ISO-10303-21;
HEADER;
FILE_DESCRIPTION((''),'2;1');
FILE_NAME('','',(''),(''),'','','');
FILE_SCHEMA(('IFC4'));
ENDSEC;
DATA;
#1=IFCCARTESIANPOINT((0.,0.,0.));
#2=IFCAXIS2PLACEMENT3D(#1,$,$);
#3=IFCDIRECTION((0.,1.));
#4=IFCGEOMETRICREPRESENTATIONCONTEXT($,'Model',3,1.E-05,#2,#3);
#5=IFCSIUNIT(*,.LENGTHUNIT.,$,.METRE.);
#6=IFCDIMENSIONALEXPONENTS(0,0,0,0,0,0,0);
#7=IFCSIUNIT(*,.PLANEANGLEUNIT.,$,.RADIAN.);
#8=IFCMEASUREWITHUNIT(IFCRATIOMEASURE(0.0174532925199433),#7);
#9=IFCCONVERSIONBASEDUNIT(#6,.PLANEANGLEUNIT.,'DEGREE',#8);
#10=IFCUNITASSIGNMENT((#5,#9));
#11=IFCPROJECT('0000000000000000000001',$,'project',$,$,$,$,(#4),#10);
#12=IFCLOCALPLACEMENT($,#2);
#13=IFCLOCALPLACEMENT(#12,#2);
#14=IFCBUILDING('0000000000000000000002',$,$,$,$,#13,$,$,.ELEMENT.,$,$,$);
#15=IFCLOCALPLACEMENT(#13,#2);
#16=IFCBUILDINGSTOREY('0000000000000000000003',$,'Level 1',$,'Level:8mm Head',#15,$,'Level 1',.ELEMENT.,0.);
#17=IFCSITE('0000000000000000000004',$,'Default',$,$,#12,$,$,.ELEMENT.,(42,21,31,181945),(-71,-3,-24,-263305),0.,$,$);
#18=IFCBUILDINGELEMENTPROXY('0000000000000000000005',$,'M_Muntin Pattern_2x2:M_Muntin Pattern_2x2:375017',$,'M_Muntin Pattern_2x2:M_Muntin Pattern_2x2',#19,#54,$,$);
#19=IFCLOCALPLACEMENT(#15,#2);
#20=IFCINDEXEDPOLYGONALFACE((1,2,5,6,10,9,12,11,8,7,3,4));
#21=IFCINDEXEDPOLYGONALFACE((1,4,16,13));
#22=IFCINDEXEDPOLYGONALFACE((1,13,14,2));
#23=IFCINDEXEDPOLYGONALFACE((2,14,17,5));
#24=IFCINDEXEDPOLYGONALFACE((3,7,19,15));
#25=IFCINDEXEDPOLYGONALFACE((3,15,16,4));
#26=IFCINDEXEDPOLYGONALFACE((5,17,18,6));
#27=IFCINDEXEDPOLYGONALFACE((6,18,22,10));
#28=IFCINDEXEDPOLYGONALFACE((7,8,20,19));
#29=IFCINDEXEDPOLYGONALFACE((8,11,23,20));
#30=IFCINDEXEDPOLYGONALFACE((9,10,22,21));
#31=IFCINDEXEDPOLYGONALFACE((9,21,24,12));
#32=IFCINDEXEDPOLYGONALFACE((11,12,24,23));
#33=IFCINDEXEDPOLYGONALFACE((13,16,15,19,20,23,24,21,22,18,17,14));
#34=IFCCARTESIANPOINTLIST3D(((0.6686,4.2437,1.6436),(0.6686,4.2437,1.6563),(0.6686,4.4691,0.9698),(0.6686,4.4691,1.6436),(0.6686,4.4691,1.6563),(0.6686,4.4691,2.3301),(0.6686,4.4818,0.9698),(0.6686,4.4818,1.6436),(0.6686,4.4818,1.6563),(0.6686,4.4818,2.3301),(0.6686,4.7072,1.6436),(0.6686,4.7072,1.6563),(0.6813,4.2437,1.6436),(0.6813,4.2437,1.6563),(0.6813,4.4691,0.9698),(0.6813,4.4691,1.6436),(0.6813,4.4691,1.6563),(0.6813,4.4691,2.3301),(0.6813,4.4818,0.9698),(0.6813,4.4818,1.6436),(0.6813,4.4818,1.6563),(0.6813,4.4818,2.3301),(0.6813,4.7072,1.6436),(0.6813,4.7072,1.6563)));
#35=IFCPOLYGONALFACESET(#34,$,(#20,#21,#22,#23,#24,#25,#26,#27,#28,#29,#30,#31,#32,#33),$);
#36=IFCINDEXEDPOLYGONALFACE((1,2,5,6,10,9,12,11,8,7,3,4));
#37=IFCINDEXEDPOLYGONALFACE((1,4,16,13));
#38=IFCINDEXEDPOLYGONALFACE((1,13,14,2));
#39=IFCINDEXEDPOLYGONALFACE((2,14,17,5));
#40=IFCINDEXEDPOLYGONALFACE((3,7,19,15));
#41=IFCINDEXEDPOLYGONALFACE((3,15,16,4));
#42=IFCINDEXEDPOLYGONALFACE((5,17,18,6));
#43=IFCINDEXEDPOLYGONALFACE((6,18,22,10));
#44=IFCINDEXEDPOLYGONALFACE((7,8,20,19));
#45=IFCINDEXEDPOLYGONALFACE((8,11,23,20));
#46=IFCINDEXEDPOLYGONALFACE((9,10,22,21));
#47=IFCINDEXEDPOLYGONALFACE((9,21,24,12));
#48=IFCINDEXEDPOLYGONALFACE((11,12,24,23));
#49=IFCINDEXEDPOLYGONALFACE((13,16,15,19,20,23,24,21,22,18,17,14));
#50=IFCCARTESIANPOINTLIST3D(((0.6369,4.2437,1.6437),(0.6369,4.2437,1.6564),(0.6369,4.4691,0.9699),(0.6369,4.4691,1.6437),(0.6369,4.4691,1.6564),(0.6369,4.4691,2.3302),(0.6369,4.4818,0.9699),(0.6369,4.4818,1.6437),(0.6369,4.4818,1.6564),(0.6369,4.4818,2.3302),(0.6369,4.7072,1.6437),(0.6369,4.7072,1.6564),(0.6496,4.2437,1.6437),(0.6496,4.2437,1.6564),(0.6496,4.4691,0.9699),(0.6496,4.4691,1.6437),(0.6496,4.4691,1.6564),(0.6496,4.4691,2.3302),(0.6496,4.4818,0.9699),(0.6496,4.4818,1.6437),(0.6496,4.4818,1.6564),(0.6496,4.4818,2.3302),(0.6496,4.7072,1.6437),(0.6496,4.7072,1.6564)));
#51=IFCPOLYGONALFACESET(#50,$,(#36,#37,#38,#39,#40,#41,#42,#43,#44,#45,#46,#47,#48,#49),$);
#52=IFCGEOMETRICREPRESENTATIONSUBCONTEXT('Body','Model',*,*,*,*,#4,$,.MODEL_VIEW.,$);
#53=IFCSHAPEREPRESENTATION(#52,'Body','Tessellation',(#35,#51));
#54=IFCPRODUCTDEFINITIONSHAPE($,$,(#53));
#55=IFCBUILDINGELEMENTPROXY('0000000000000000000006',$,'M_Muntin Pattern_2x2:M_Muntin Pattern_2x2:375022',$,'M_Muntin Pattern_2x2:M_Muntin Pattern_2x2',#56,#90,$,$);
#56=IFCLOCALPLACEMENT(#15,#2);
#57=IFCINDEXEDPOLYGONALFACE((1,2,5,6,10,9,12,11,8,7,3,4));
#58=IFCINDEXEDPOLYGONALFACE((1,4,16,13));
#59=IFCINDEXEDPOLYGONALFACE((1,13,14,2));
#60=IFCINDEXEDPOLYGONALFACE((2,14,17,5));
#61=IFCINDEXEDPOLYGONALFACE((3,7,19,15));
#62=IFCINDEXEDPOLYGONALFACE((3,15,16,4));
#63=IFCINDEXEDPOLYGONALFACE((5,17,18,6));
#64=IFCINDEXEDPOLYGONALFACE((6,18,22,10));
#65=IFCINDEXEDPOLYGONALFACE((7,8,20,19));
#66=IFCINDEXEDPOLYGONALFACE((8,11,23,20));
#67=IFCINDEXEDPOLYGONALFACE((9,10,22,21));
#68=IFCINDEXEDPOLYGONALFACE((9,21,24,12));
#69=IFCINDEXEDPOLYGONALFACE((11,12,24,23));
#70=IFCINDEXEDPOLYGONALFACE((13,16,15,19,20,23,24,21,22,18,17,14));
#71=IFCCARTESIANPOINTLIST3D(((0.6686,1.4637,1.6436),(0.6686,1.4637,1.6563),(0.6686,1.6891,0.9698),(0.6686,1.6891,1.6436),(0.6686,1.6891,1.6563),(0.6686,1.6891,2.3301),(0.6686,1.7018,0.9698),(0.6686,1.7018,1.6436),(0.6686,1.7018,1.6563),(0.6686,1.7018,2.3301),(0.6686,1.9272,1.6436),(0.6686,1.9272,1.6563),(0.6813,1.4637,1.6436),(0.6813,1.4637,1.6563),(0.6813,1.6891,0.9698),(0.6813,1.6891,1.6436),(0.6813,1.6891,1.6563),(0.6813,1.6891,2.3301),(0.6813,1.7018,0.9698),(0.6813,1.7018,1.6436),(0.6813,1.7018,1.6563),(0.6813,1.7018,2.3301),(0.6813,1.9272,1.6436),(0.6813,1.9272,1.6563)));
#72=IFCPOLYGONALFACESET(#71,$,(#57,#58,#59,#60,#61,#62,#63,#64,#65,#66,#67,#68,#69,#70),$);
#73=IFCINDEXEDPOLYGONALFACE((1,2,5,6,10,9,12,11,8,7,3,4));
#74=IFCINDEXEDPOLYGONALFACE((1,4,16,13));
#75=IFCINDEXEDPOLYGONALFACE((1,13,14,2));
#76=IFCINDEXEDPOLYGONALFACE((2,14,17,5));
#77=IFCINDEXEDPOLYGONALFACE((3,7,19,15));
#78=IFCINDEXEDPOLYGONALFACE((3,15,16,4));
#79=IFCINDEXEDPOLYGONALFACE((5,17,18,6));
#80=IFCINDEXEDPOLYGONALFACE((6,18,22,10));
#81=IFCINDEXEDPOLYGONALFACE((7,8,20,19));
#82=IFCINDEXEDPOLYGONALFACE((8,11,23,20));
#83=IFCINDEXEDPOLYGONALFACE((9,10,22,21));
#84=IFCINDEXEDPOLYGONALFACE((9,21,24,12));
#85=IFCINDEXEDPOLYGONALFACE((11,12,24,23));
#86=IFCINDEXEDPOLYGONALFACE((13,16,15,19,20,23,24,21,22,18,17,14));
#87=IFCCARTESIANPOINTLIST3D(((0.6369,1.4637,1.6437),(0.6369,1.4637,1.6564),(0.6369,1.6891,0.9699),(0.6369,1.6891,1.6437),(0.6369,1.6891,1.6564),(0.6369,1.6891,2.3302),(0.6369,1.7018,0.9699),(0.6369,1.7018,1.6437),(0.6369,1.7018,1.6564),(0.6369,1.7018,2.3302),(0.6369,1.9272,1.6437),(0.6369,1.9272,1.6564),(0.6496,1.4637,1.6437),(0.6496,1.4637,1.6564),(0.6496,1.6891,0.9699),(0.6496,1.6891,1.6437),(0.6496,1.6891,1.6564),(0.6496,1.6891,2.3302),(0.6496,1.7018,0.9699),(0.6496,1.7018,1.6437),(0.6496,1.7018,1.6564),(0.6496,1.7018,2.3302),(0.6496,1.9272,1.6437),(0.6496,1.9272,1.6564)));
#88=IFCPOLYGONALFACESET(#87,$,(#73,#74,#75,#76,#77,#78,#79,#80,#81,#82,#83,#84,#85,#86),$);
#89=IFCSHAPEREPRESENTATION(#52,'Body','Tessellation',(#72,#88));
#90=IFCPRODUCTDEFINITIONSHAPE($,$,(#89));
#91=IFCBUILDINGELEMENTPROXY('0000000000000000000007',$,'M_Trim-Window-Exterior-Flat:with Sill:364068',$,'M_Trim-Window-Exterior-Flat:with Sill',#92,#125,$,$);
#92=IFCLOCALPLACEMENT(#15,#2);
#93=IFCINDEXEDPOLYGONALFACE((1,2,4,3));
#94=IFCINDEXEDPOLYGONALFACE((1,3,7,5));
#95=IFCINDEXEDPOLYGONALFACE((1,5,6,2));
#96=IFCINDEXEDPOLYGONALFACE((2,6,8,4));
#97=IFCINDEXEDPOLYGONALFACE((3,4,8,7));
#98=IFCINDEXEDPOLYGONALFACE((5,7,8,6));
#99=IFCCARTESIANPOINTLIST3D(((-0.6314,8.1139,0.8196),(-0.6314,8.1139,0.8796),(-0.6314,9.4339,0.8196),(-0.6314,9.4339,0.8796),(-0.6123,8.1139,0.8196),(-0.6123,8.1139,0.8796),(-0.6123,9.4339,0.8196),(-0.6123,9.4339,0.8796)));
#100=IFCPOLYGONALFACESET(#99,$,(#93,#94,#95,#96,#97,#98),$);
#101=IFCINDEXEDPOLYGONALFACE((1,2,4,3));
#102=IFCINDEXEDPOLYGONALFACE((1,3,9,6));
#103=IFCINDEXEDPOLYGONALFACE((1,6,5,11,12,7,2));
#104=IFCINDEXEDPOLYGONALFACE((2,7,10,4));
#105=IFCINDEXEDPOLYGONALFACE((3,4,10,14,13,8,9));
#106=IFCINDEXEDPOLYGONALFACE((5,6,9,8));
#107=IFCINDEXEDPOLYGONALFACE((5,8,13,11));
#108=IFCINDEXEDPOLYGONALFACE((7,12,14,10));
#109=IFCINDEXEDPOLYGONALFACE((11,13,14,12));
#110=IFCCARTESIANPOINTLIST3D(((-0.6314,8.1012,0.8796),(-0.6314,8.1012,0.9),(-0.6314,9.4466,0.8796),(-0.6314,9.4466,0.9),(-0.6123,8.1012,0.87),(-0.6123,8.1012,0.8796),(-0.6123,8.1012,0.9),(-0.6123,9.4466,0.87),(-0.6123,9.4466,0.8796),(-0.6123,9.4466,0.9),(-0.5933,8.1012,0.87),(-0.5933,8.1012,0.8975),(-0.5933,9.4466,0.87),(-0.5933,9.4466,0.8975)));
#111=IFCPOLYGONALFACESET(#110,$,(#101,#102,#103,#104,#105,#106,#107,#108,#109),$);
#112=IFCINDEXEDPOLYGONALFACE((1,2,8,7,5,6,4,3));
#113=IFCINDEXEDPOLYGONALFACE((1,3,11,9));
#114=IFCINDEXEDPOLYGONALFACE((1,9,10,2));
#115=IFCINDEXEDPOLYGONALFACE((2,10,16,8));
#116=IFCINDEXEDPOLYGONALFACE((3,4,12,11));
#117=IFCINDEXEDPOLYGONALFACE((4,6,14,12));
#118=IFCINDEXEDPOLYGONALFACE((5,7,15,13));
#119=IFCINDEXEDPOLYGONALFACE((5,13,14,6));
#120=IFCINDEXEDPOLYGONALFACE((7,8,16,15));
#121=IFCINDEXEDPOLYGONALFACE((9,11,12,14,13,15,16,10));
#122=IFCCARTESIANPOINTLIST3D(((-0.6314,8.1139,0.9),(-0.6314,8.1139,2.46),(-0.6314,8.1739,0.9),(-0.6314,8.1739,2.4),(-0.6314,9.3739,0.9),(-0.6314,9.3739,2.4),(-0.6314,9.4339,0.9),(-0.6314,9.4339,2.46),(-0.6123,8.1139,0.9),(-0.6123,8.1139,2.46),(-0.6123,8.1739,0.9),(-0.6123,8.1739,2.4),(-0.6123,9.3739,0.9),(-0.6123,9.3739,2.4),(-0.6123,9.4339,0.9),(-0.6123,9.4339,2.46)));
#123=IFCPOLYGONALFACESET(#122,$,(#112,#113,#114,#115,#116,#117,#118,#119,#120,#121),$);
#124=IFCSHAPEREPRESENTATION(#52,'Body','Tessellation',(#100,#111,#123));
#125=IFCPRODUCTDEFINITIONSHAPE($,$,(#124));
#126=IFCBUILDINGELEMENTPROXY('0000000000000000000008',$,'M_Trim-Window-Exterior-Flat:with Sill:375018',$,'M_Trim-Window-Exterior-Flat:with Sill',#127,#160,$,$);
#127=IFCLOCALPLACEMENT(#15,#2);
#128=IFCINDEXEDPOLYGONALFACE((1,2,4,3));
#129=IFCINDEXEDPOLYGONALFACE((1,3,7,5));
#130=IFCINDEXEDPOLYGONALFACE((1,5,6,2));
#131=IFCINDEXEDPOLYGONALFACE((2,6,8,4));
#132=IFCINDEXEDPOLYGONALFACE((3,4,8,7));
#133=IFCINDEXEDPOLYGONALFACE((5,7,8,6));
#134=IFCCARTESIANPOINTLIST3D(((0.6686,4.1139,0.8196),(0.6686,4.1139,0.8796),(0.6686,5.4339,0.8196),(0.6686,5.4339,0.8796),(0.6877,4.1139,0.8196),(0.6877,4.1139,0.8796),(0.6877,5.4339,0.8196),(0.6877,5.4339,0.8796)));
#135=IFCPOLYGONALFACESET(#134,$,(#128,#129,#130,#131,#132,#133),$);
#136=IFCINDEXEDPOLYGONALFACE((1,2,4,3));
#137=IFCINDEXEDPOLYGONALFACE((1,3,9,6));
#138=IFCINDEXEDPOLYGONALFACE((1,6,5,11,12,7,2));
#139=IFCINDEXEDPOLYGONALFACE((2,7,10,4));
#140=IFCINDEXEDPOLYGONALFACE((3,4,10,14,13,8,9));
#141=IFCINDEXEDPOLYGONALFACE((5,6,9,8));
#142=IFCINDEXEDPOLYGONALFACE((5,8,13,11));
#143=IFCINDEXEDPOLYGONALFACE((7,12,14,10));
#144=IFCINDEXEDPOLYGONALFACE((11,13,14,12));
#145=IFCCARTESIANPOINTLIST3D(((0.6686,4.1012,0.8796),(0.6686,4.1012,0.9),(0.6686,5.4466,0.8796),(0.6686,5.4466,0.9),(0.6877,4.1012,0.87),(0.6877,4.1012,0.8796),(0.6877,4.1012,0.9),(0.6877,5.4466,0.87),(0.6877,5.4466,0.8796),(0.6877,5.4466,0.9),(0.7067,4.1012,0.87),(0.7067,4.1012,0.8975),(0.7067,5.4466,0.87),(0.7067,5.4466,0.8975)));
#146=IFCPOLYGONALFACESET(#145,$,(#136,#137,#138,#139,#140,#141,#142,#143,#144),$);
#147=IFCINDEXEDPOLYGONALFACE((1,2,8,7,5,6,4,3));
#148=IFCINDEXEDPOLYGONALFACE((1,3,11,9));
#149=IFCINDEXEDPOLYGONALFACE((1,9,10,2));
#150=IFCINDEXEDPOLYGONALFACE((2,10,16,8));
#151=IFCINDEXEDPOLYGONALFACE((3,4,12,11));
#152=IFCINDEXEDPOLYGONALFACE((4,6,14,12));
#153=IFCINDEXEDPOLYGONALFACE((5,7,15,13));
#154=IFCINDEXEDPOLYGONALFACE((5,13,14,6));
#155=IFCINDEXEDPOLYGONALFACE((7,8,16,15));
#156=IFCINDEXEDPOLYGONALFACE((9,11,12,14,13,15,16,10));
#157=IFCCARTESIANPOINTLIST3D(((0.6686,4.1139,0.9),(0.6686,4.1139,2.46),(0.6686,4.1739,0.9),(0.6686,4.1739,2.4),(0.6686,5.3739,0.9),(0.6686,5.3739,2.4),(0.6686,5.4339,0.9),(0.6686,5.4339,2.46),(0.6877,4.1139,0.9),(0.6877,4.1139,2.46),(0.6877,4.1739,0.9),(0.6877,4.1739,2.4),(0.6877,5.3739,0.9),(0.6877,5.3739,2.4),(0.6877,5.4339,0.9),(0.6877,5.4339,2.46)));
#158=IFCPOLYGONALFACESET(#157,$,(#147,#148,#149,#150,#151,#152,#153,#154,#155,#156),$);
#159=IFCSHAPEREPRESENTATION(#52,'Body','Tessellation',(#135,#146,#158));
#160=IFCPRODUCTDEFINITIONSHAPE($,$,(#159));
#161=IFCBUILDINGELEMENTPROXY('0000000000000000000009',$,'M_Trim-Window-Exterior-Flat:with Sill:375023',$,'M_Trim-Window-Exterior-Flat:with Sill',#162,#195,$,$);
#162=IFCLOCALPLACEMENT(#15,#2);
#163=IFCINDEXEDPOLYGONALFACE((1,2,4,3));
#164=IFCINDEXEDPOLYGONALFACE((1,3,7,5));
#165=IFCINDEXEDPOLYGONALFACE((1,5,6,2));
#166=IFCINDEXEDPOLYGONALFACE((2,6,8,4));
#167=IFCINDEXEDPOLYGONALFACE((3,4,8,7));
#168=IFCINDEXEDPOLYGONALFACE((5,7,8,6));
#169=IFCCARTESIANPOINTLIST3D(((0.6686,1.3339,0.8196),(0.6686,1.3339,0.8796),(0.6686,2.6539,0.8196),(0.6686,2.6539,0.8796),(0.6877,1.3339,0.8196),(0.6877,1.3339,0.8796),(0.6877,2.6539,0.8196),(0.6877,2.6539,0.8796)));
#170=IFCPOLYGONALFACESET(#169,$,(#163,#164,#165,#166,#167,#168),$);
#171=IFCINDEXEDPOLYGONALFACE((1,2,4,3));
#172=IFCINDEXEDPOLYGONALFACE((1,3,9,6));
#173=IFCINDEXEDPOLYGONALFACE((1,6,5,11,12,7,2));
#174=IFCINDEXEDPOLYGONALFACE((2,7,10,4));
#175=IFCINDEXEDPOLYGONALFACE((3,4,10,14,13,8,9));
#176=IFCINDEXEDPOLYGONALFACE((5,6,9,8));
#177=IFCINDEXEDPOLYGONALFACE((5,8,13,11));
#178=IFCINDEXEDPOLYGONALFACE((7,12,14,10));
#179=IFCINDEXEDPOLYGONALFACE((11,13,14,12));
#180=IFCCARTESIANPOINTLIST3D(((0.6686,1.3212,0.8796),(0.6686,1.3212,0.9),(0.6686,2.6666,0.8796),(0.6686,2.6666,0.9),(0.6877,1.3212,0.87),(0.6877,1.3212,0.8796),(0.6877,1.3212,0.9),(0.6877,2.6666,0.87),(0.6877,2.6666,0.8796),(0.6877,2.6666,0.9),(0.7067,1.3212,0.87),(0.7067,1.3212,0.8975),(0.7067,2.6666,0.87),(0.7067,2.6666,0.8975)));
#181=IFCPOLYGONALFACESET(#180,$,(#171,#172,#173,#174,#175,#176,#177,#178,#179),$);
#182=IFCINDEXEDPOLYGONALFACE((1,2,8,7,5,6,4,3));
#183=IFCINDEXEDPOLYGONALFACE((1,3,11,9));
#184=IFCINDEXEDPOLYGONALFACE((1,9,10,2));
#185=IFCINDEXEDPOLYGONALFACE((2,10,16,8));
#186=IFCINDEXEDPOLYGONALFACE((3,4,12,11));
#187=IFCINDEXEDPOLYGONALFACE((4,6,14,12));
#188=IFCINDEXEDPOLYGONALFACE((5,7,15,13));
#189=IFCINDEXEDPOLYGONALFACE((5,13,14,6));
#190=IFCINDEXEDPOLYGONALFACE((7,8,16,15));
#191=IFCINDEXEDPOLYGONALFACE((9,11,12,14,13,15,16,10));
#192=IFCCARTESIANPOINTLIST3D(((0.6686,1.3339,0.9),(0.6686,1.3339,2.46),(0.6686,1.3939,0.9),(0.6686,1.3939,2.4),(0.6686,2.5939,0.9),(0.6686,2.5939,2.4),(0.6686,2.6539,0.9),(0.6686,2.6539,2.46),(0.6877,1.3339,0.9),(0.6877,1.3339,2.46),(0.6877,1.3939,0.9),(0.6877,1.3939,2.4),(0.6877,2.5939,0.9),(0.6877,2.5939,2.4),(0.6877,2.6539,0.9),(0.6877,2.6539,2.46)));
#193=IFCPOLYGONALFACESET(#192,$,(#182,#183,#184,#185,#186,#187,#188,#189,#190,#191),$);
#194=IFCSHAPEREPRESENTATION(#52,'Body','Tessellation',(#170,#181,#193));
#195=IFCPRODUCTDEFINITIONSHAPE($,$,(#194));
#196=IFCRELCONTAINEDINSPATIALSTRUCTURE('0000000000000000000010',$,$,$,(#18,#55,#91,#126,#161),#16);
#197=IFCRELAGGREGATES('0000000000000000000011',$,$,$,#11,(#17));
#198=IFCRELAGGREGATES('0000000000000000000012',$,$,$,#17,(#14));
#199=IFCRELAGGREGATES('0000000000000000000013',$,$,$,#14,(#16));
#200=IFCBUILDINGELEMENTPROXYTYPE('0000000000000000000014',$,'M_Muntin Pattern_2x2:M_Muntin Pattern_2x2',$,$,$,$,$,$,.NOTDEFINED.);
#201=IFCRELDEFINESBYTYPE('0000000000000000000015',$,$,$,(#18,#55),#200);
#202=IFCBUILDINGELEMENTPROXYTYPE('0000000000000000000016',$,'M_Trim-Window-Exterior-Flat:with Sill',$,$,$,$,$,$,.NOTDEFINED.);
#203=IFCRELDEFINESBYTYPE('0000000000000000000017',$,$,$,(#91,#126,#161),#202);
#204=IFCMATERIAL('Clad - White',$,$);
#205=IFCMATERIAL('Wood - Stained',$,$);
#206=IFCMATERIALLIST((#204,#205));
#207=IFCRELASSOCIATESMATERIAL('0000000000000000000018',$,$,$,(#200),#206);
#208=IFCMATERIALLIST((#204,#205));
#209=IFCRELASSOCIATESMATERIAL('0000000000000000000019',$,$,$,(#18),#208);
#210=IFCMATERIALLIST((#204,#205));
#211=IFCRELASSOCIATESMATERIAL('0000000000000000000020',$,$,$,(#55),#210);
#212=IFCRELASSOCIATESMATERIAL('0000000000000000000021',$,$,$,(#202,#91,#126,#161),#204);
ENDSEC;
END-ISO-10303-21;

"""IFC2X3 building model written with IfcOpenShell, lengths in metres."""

from ifc_helpers import new_model, entity, si_unit, converted_unit, direction, frame, frame_2d, origin, place, context, subcontext, project, spatial, polyline, rectangle, outline, extrude, source, transform, mapped, material, material_list, type_object, type_shapes, element, save


model = new_model("IFC2X3")

# Units and contexts
model_context = context("Model", 3, precision=1e-05, world=origin(), true_north=direction((0.0, 1.0)))
body_context = subcontext(model_context, "Body", "Model", "MODEL_VIEW")
ifc_project = project(units=[si_unit("LENGTHUNIT", "METRE"), converted_unit("PLANEANGLEUNIT", "DEGREE", entity("IfcRatioMeasure", 0.0174532925199433), si_unit("PLANEANGLEUNIT", "RADIAN"), dimensions=[0, 0, 0, 0, 0, 0, 0])], contexts=[model_context])

# Site, building, storey
site_placement = place(None, origin())
site = spatial("IfcSite", under=ifc_project, at=site_placement, Name="Default", CompositionType="ELEMENT", RefLatitude=(42, 21, 31, 181945), RefLongitude=(-71, -3, -24, -263305), RefElevation=0.0)
building_placement = place(site_placement, origin())
building = spatial("IfcBuilding", under=site, at=building_placement, CompositionType="ELEMENT")
storey_placement = place(building_placement, origin())
storey = spatial("IfcBuildingStorey", under=building, at=storey_placement, Name="Level 1", ObjectType="Level:8mm Head", LongName="Level 1", CompositionType="ELEMENT", Elevation=0.0)

# Building element proxies
ifc_material_1 = material(Name="Clad - White")
ifc_material_2 = material(Name="Wood - Stained")
ifc_material_list_1 = material_list([ifc_material_1, ifc_material_2])
building_element_proxy_type_1 = type_object("IfcBuildingElementProxyType", Name="M_Muntin Pattern_2x2:M_Muntin Pattern_2x2", PredefinedType="NOTDEFINED", material=ifc_material_list_1)
shared_shape_1 = source(origin(), body_context, "Body", "SweptSolid", [
    extrude(outline(polyline([(0.0064, -0.0064), (0.6801, -0.0064), (0.6801, 0.0063), (0.0064, 0.0063), (0.0064, 0.2317), (-0.0063, 0.2317), (-0.0063, 0.0063), (-0.6802, 0.0063), (-0.6802, -0.0064), (-0.0063, -0.0064), (-0.0063, -0.2317), (0.0064, -0.2317), (0.0064, -0.0064)])), frame((0.0, -0.0222, 0.6801), z_axis=(0.0, 1.0, 0.0), x_axis=(0.0, 0.0, 1.0)), (0.0, 0.0, 1.0), 0.0127),
    extrude(outline(polyline([(0.0064, -0.0064), (0.6802, -0.0064), (0.6802, 0.0063), (0.0064, 0.0063), (0.0064, 0.2317), (-0.0063, 0.2317), (-0.0063, 0.0063), (-0.6802, 0.0063), (-0.6802, -0.0064), (-0.0063, -0.0064), (-0.0063, -0.2317), (0.0064, -0.2317), (0.0064, -0.0064)])), frame((0.0, 0.0095, 0.6802), z_axis=(0.0, 1.0, 0.0), x_axis=(0.0, 0.0, 1.0)), (0.0, 0.0, 1.0), 0.0127),
])
type_shapes(building_element_proxy_type_1, [shared_shape_1])
ifc_material_list_2 = material_list([ifc_material_1, ifc_material_2])
proxy_1_placement = place(storey_placement, frame((0.6591, 4.4754, 0.9699), z_axis=(0.0, 0.0, 1.0), x_axis=(0.0, 1.0, 0.0)))
element("IfcBuildingElementProxy", 1, at=proxy_1_placement, inside=storey, type_object=building_element_proxy_type_1, material=ifc_material_list_2, Name="M_Muntin Pattern_2x2:M_Muntin Pattern_2x2:375017", ObjectType="M_Muntin Pattern_2x2:M_Muntin Pattern_2x2", context=body_context, shape_type="MappedRepresentation", body=[
    mapped(shared_shape_1, transform((0.0, 0.0, 0.0), scale=1.0)),
])
ifc_material_list_3 = material_list([ifc_material_1, ifc_material_2])
proxy_2_placement = place(storey_placement, frame((0.6591, 1.6954, 0.9699), z_axis=(0.0, 0.0, 1.0), x_axis=(0.0, 1.0, 0.0)))
element("IfcBuildingElementProxy", 2, at=proxy_2_placement, inside=storey, type_object=building_element_proxy_type_1, material=ifc_material_list_3, Name="M_Muntin Pattern_2x2:M_Muntin Pattern_2x2:375022", ObjectType="M_Muntin Pattern_2x2:M_Muntin Pattern_2x2", context=body_context, shape_type="MappedRepresentation", body=[
    mapped(shared_shape_1, transform((0.0, 0.0, 0.0), scale=1.0)),
])
building_element_proxy_type_2 = type_object("IfcBuildingElementProxyType", Name="M_Trim-Window-Exterior-Flat:with Sill", PredefinedType="NOTDEFINED", material=ifc_material_1)
shared_shape_2 = source(origin(), body_context, "Body", "SweptSolid", [
    extrude(rectangle(XDim=1.32, YDim=0.06, at=frame_2d((0.0, 0.0), x_axis=(1.0, 0.0))), frame((0.0, -1.5504, 0.0), z_axis=(0.0, 0.0, 1.0), x_axis=(-1.0, 0.0, 0.0)), (0.0, 0.0, 1.0), 0.0191),
    extrude(outline(polyline([(-0.019, -0.0152), (0.0, -0.0152), (0.0, -0.0057), (0.019, -0.0057), (0.019, 0.0148), (0.0, 0.0148), (-0.019, 0.0123), (-0.019, -0.0152)])), frame((-0.6727, -1.5148, 0.019), z_axis=(1.0, 0.0, 0.0), x_axis=(0.0, 0.0, -1.0)), (0.0, 0.0, 1.0), 1.3454),
    extrude(outline(polyline([(-0.795, -0.66), (0.765, -0.66), (0.765, -0.6), (-0.735, -0.6), (-0.735, 0.6), (0.765, 0.6), (0.765, 0.66), (-0.795, 0.66), (-0.795, -0.66)])), frame((0.0, -0.735, 0.0), z_axis=(0.0, 0.0, 1.0), x_axis=(0.0, -1.0, 0.0)), (0.0, 0.0, 1.0), 0.0191),
])
type_shapes(building_element_proxy_type_2, [shared_shape_2])
for number, where, z_axis, x_axis, name in (
    (3, (-0.6314, 8.7739, 2.4), (1.0, 0.0, 0.0), (0.0, 1.0, 0.0), "M_Trim-Window-Exterior-Flat:with Sill:364068"),
    (4, (0.6686, 4.7739, 2.4), (1.0, 0.0, 0.0), (0.0, 1.0, 0.0), "M_Trim-Window-Exterior-Flat:with Sill:375018"),
    (5, (0.6686, 1.9939, 2.4), (1.0, 0.0, 0.0), (0.0, 1.0, 0.0), "M_Trim-Window-Exterior-Flat:with Sill:375023"),
):
    element("IfcBuildingElementProxy", number, at=place(storey_placement, frame(where, z_axis=z_axis, x_axis=x_axis)), inside=storey, type_object=building_element_proxy_type_2, material=ifc_material_1, Name=name, ObjectType="M_Trim-Window-Exterior-Flat:with Sill", context=body_context, shape_type="MappedRepresentation", body=[
        mapped(shared_shape_2, transform((0.0, 0.0, 0.0), scale=1.0)),
    ])

save(model, "model.ifc")
